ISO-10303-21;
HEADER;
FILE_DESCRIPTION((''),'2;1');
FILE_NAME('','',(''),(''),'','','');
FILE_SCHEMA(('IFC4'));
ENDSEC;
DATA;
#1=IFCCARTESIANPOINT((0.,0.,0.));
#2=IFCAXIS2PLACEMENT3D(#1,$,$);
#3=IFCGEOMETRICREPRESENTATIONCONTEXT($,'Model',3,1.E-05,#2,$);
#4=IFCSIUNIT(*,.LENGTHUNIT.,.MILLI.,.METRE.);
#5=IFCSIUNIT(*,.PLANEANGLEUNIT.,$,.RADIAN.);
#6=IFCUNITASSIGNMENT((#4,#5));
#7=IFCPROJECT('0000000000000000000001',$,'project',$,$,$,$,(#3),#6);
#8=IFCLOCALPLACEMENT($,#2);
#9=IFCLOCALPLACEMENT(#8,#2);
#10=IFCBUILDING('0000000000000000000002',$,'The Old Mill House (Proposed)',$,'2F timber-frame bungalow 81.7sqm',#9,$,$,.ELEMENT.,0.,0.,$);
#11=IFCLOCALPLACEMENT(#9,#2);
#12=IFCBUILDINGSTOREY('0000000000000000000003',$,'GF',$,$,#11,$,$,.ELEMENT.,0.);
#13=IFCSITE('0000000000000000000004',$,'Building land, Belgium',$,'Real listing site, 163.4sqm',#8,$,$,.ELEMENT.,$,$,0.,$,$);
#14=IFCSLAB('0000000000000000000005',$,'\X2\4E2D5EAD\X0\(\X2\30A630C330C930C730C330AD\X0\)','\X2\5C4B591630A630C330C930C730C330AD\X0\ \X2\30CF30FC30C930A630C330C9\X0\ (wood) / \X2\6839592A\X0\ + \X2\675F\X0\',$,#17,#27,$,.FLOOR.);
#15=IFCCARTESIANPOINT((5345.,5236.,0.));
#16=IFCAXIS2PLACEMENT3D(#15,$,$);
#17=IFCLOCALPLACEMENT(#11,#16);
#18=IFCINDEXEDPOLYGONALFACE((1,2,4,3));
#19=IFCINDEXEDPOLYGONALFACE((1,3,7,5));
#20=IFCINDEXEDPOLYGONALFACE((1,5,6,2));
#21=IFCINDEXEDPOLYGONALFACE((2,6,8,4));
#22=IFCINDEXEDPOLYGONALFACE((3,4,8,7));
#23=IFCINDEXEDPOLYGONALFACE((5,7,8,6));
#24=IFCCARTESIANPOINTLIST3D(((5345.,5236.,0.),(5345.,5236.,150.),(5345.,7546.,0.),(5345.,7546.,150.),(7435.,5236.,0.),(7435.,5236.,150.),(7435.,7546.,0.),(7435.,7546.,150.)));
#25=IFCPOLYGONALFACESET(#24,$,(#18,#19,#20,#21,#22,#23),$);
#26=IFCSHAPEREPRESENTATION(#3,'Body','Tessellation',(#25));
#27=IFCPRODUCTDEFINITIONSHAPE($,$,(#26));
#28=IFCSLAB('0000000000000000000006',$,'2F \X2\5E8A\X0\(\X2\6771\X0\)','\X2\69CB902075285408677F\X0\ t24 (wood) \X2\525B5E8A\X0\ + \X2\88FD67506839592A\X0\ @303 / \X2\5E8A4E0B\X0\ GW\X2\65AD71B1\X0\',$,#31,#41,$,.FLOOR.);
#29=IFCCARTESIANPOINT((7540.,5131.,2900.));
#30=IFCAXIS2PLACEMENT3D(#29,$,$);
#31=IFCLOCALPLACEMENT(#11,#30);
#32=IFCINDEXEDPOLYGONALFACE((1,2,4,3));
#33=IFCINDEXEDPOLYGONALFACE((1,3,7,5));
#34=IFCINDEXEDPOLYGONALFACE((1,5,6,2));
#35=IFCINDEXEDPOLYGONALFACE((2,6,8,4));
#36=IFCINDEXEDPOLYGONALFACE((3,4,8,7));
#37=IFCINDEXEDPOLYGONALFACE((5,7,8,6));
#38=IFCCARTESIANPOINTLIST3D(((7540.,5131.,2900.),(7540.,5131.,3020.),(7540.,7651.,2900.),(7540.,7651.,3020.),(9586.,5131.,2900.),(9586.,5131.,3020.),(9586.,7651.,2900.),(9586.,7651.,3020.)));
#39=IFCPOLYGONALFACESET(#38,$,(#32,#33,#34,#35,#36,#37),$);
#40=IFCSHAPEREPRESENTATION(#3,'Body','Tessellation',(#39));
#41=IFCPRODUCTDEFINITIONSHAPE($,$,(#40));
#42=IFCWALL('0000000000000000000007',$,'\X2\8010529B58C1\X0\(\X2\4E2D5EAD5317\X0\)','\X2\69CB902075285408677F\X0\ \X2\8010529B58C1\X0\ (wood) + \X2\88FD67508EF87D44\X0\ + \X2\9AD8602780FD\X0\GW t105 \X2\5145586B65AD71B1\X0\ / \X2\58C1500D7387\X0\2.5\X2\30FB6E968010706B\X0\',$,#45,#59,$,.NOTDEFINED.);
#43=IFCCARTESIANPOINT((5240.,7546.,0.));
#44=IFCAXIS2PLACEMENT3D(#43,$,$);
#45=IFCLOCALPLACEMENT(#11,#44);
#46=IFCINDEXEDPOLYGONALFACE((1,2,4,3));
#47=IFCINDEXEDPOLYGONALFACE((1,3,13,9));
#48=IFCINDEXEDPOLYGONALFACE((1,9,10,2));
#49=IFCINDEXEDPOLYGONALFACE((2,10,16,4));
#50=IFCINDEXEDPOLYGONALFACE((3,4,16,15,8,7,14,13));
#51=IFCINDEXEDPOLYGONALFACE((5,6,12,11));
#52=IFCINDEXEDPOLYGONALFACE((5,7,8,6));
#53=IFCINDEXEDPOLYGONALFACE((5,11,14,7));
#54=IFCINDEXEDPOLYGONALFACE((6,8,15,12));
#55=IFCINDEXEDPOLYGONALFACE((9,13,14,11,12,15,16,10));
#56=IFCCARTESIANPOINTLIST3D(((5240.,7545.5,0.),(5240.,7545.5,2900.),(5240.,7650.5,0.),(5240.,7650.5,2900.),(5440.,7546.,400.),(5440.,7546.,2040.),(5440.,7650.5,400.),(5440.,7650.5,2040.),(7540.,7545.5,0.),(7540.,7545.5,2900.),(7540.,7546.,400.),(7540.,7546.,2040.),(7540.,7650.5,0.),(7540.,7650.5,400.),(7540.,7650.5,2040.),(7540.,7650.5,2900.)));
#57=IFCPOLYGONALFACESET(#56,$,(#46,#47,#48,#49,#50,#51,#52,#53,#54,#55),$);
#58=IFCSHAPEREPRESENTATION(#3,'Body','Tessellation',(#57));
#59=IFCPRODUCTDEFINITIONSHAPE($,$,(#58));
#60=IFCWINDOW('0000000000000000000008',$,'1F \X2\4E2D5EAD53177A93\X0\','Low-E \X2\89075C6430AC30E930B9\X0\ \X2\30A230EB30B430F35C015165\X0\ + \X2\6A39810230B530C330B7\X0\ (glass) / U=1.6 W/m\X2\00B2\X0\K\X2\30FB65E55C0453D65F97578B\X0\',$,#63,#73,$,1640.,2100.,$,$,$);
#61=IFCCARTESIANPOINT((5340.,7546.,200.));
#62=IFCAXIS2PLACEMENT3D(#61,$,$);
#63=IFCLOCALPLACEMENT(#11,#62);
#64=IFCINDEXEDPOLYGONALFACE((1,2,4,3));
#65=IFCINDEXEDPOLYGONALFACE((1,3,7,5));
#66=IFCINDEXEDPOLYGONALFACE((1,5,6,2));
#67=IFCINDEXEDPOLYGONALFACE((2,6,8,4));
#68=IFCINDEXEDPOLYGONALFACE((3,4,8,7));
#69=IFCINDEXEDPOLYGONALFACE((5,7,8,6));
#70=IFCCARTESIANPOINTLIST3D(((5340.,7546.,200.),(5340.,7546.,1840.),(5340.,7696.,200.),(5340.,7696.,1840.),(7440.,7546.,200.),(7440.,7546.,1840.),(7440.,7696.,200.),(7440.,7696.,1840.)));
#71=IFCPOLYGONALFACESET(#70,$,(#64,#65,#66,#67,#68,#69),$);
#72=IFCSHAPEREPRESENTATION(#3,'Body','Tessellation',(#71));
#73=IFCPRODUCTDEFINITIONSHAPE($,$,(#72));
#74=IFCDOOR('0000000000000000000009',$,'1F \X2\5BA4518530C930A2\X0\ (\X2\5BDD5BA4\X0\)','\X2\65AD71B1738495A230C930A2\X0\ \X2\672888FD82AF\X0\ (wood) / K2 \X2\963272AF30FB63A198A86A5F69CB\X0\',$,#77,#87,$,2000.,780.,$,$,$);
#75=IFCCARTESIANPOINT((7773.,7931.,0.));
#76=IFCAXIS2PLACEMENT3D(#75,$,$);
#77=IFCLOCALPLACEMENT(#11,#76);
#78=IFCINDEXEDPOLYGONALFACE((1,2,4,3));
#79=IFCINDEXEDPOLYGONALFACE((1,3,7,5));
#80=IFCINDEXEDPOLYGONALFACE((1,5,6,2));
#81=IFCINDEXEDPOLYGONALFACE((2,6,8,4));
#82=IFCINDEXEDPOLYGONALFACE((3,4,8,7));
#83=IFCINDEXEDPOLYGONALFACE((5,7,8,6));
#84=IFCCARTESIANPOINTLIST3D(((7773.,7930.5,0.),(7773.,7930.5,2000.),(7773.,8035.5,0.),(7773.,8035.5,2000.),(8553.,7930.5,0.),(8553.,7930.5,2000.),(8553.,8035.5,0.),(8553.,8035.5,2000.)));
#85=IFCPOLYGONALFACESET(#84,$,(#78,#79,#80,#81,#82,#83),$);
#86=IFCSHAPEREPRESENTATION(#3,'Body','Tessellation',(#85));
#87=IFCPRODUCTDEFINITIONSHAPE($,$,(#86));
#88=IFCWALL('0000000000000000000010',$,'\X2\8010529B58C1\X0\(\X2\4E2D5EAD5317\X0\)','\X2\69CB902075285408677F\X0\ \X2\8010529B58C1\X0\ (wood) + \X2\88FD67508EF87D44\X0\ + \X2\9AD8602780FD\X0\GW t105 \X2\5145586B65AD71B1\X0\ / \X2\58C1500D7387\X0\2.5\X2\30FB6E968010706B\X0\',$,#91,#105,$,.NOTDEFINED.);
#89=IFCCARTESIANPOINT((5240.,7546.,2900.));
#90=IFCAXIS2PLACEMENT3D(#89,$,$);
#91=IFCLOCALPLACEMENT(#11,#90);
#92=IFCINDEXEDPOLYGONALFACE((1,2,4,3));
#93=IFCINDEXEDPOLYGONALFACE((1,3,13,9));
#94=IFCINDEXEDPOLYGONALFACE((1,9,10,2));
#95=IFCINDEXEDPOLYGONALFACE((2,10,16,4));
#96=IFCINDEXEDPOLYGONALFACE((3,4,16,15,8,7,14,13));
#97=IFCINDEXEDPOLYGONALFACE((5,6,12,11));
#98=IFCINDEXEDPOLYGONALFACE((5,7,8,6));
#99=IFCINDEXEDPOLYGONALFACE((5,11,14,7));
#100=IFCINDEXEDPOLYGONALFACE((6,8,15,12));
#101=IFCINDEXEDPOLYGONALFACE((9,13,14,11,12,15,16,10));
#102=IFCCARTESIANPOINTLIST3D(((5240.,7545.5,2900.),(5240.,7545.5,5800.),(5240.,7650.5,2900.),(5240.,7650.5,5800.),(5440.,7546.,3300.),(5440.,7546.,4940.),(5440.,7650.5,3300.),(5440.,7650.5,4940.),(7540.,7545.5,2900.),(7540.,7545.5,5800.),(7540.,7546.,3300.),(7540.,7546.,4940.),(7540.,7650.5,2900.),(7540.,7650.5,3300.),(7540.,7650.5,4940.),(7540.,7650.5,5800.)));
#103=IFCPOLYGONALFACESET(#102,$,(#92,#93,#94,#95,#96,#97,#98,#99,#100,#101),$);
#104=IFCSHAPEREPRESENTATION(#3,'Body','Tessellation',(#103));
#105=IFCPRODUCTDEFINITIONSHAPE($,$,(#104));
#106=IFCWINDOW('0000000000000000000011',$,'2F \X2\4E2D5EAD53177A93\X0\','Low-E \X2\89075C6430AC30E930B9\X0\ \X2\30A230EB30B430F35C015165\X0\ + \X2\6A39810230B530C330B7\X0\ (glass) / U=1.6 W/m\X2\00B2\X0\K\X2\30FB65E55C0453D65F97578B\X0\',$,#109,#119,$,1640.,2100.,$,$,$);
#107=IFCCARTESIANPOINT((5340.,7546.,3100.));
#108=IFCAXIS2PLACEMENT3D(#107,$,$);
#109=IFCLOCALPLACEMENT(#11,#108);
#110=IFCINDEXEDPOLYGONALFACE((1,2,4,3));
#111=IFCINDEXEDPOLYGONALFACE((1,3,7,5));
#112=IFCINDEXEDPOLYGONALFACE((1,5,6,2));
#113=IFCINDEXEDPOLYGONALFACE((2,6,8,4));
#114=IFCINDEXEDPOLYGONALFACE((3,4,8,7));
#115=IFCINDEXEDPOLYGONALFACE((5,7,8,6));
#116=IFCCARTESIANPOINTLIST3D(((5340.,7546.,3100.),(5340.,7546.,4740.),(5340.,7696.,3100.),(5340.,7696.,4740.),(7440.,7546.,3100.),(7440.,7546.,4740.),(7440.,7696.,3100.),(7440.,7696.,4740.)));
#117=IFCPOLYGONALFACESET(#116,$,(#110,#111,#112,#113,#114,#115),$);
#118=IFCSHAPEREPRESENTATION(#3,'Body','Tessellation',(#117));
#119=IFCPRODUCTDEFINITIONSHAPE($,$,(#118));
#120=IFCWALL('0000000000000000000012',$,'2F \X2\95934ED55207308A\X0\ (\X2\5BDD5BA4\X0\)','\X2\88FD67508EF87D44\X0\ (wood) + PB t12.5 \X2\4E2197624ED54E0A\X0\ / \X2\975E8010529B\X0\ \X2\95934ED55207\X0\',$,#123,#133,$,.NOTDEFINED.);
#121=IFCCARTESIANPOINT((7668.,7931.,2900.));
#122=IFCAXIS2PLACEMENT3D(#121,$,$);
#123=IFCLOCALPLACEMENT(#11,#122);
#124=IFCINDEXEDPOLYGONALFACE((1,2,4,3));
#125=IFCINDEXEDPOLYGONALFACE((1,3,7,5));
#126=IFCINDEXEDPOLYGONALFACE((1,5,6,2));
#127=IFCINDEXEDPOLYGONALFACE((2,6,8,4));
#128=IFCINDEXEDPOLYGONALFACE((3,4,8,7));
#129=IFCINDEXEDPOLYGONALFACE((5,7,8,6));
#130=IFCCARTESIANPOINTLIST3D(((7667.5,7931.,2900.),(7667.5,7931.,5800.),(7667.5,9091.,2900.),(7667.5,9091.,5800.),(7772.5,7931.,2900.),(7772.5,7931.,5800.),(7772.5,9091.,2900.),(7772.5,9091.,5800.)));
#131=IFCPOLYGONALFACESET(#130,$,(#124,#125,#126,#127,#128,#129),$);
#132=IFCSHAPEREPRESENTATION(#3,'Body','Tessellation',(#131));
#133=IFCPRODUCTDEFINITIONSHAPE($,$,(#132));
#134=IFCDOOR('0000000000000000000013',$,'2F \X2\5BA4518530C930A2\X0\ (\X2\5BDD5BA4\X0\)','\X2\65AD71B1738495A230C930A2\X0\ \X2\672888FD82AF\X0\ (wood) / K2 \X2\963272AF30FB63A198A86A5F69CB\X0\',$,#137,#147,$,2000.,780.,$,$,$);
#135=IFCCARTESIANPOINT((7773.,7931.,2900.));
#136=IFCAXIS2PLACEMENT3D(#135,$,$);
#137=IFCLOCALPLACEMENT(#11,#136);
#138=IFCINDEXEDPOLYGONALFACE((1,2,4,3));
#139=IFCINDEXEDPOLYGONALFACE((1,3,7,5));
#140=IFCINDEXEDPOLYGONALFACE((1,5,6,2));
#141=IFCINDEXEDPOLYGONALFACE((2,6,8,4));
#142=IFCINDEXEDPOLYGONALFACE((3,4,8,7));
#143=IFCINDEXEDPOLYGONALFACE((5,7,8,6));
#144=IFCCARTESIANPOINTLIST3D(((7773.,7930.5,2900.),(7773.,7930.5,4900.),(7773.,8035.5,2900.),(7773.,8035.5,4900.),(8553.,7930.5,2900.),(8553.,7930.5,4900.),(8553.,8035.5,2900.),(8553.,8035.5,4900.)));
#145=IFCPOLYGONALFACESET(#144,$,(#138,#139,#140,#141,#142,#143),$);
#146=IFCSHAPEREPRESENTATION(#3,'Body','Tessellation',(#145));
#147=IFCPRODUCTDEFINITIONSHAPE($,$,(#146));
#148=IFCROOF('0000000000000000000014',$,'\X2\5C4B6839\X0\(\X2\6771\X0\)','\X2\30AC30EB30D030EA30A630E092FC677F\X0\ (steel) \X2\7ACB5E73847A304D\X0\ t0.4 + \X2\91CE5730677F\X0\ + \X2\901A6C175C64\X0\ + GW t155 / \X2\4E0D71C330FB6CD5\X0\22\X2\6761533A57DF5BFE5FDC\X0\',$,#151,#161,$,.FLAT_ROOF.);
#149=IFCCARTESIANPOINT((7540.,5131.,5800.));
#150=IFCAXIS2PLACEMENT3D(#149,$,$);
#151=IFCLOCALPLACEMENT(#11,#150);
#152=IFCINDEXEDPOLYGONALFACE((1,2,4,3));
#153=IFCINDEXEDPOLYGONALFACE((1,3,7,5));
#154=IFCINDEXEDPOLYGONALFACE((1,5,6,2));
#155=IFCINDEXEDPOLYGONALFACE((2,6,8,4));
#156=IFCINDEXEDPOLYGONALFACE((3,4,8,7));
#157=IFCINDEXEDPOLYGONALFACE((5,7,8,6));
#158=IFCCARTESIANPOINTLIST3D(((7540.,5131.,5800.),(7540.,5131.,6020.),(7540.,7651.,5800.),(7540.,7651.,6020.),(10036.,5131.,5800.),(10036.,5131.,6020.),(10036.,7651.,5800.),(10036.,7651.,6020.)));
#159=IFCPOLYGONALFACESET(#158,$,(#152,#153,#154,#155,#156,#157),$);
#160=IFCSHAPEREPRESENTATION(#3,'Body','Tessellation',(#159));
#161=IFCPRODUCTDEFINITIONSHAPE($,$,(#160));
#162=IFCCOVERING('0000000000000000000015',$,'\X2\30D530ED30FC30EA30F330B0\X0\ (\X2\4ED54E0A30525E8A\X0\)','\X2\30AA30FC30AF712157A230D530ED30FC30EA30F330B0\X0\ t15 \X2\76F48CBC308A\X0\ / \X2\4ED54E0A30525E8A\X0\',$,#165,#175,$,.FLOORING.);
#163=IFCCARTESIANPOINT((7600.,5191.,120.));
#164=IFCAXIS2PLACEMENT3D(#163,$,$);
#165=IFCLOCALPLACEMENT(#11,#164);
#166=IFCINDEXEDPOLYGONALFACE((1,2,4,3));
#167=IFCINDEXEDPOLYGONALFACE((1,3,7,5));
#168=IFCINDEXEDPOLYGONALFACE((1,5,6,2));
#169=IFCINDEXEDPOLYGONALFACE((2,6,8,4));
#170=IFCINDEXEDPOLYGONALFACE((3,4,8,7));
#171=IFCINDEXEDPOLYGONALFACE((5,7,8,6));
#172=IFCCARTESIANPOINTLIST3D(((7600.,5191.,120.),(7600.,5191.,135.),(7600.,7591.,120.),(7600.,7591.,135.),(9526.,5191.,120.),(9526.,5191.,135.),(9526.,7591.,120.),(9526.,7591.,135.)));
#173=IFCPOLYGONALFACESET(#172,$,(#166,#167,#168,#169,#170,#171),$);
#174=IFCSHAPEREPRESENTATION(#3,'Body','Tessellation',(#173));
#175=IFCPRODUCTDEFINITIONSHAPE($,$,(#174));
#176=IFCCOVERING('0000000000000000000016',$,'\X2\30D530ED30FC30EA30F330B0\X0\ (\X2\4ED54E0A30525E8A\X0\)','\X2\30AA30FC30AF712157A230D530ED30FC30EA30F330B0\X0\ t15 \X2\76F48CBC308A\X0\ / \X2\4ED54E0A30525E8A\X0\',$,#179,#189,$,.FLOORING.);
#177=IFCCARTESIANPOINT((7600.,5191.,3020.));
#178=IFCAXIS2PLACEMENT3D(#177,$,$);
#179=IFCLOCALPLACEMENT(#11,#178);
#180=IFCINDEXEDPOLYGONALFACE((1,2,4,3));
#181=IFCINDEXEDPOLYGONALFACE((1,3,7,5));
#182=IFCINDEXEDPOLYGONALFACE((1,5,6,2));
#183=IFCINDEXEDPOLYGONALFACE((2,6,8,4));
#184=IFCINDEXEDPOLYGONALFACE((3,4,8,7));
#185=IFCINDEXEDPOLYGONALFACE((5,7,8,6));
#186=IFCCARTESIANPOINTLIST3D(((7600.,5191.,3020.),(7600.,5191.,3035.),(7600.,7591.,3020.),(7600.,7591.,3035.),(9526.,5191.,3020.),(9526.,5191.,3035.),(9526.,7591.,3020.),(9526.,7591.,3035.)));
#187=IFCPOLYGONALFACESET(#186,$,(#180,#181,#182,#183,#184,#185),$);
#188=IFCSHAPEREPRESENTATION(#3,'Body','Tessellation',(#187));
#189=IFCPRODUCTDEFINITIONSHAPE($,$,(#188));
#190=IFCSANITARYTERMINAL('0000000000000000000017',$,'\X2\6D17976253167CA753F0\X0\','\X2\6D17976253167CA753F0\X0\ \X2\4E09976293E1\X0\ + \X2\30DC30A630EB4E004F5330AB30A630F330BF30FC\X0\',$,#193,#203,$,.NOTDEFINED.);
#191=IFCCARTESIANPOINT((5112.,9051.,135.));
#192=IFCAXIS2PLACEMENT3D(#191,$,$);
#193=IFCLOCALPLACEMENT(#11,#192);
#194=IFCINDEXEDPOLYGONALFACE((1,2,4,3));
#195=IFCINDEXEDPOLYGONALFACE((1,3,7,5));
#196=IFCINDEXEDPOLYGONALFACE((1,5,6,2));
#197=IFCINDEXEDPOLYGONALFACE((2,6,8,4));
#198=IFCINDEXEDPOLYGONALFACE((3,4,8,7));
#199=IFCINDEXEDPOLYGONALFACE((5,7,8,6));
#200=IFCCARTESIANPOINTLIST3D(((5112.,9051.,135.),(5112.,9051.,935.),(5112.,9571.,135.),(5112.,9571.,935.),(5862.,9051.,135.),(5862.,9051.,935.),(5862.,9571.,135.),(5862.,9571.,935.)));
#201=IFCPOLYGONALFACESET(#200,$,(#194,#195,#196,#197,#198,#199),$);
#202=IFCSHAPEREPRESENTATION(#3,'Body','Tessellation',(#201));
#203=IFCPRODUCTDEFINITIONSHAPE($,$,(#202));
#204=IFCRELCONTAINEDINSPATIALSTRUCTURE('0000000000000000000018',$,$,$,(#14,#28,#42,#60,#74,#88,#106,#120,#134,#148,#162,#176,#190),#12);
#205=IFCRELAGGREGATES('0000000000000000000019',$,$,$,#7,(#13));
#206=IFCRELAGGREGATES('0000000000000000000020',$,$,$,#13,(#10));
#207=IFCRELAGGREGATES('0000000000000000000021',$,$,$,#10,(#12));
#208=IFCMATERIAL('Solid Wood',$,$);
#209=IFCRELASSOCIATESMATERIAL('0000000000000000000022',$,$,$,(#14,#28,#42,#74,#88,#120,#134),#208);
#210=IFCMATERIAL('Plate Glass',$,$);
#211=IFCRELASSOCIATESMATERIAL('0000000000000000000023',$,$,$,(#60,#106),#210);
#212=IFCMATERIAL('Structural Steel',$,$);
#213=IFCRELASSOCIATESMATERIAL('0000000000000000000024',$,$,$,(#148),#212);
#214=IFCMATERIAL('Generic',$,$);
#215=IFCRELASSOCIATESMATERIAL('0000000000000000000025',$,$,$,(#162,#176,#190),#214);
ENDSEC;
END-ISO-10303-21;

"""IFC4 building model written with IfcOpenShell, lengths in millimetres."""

from ifc_helpers import new_model, si_unit, frame, frame_2d, origin, place, context, project, spatial, rectangle, extrude, material, element, fill, save


model = new_model("IFC4")

# Units and contexts
model_context = context("Model", 3, precision=1e-05, world=origin())
ifc_project = project(units=[si_unit("LENGTHUNIT", "METRE", prefix="MILLI"), si_unit("PLANEANGLEUNIT", "RADIAN")], contexts=[model_context])

# Site, building, storey
site_placement = place(None, origin())
site = spatial("IfcSite", under=ifc_project, at=site_placement, Name="Building land, Belgium", ObjectType="Real listing site, 163.4sqm", CompositionType="ELEMENT", RefElevation=0.0)
building_placement = place(site_placement, origin())
building = spatial("IfcBuilding", under=site, at=building_placement, Name="The Old Mill House (Proposed)", ObjectType="2F timber-frame bungalow 81.7sqm", CompositionType="ELEMENT", ElevationOfRefHeight=0.0, ElevationOfTerrain=0.0)
storey_placement = place(building_placement, origin())
storey = spatial("IfcBuildingStorey", under=building, at=storey_placement, Name="GF", CompositionType="ELEMENT", Elevation=0.0)

# Slabs
ifc_material_1 = material(Name="Solid Wood")
slab_1_placement = place(storey_placement, frame((5345.0, 5236.0, 0.0)))
element("IfcSlab", 1, at=slab_1_placement, inside=storey, material=ifc_material_1, Name="中庭(ウッドデッキ)", Description="屋外ウッドデッキ ハードウッド (wood) / 根太 + 束", PredefinedType="FLOOR", context=model_context, shape_type="SweptSolid", body=[
    extrude(rectangle(XDim=2090.0, YDim=2310.0, at=frame_2d((1045.0, 1155.0))), frame((5345.0, 5236.0, 0.0)), (0.0, 0.0, 1.0), 150.0),
])
slab_2_placement = place(storey_placement, frame((7540.0, 5131.0, 2900.0)))
element("IfcSlab", 2, at=slab_2_placement, inside=storey, material=ifc_material_1, Name="2F 床(東)", Description="構造用合板 t24 (wood) 剛床 + 製材根太 @303 / 床下 GW断熱", PredefinedType="FLOOR", context=model_context, shape_type="SweptSolid", body=[
    extrude(rectangle(XDim=2046.0, YDim=2520.0, at=frame_2d((1023.0, 1260.0))), frame((7540.0, 5131.0, 2900.0)), (0.0, 0.0, 1.0), 120.0),
])

# Wall, opening, window
wall_1_placement = place(storey_placement, frame((5240.0, 7546.0, 0.0)))
wall_1 = element("IfcWall", 3, at=wall_1_placement, inside=storey, material=ifc_material_1, Name="耐力壁(中庭北)", Description="構造用合板 耐力壁 (wood) + 製材軸組 + 高性能GW t105 充填断熱 / 壁倍率2.5・準耐火", PredefinedType="NOTDEFINED", context=model_context, shape_type="SweptSolid", body=[
    extrude(rectangle(XDim=2300.0, YDim=105.0, at=frame_2d((1150.0, 52.0))), frame((5240.0, 7546.0, 0.0)), (0.0, 0.0, 1.0), 2900.0),
])
opening_1_placement = place(storey_placement, frame((5340.0, 7546.0, 200.0)))
opening_1 = element("IfcOpeningElement", 4, at=opening_1_placement, cuts=wall_1, PredefinedType="NOTDEFINED", context=model_context, shape_type="SweptSolid", body=[
    extrude(rectangle(XDim=2100.0, YDim=150.0, at=frame_2d((1050.0, 75.0))), frame((5340.0, 7546.0, 200.0)), (0.0, 0.0, 1.0), 1640.0),
])
ifc_material_2 = material(Name="Plate Glass")
window_1_placement = place(storey_placement, frame((5340.0, 7546.0, 200.0)))
window_1 = element("IfcWindow", 5, at=window_1_placement, inside=storey, material=ifc_material_2, Name="1F 中庭北窓", Description="Low-E 複層ガラス アルゴン封入 + 樹脂サッシ (glass) / U=1.6 W/m²K・日射取得型", OverallHeight=1640.0, OverallWidth=2100.0, context=model_context, shape_type="SweptSolid", body=[
    extrude(rectangle(XDim=2100.0, YDim=150.0, at=frame_2d((1050.0, 75.0))), frame((5340.0, 7546.0, 200.0)), (0.0, 0.0, 1.0), 1640.0),
])
fill(opening_1, window_1)

# Door
door_1_placement = place(storey_placement, frame((7773.0, 7931.0, 0.0)))
element("IfcDoor", 6, at=door_1_placement, inside=storey, material=ifc_material_1, Name="1F 室内ドア (寝室)", Description="断熱玄関ドア 木製芯 (wood) / K2 防犯・採風機構", OverallHeight=2000.0, OverallWidth=780.0, context=model_context, shape_type="SweptSolid", body=[
    extrude(rectangle(XDim=780.0, YDim=105.0, at=frame_2d((390.0, 52.0))), frame((7773.0, 7931.0, 0.0)), (0.0, 0.0, 1.0), 2000.0),
])

# Wall, opening, window
wall_2_placement = place(storey_placement, frame((5240.0, 7546.0, 2900.0)))
wall_2 = element("IfcWall", 7, at=wall_2_placement, inside=storey, material=ifc_material_1, Name="耐力壁(中庭北)", Description="構造用合板 耐力壁 (wood) + 製材軸組 + 高性能GW t105 充填断熱 / 壁倍率2.5・準耐火", PredefinedType="NOTDEFINED", context=model_context, shape_type="SweptSolid", body=[
    extrude(rectangle(XDim=2300.0, YDim=105.0, at=frame_2d((1150.0, 52.0))), frame((5240.0, 7546.0, 2900.0)), (0.0, 0.0, 1.0), 2900.0),
])
opening_2_placement = place(storey_placement, frame((5340.0, 7546.0, 3100.0)))
opening_2 = element("IfcOpeningElement", 8, at=opening_2_placement, cuts=wall_2, PredefinedType="NOTDEFINED", context=model_context, shape_type="SweptSolid", body=[
    extrude(rectangle(XDim=2100.0, YDim=150.0, at=frame_2d((1050.0, 75.0))), frame((5340.0, 7546.0, 3100.0)), (0.0, 0.0, 1.0), 1640.0),
])
window_2_placement = place(storey_placement, frame((5340.0, 7546.0, 3100.0)))
window_2 = element("IfcWindow", 9, at=window_2_placement, inside=storey, material=ifc_material_2, Name="2F 中庭北窓", Description="Low-E 複層ガラス アルゴン封入 + 樹脂サッシ (glass) / U=1.6 W/m²K・日射取得型", OverallHeight=1640.0, OverallWidth=2100.0, context=model_context, shape_type="SweptSolid", body=[
    extrude(rectangle(XDim=2100.0, YDim=150.0, at=frame_2d((1050.0, 75.0))), frame((5340.0, 7546.0, 3100.0)), (0.0, 0.0, 1.0), 1640.0),
])
fill(opening_2, window_2)

# Wall
wall_3_placement = place(storey_placement, frame((7668.0, 7931.0, 2900.0)))
element("IfcWall", 10, at=wall_3_placement, inside=storey, material=ifc_material_1, Name="2F 間仕切り (寝室)", Description="製材軸組 (wood) + PB t12.5 両面仕上 / 非耐力 間仕切", PredefinedType="NOTDEFINED", context=model_context, shape_type="SweptSolid", body=[
    extrude(rectangle(XDim=105.0, YDim=1160.0, at=frame_2d((52.0, 580.0))), frame((7668.0, 7931.0, 2900.0)), (0.0, 0.0, 1.0), 2900.0),
])

# Door
door_2_placement = place(storey_placement, frame((7773.0, 7931.0, 2900.0)))
element("IfcDoor", 11, at=door_2_placement, inside=storey, material=ifc_material_1, Name="2F 室内ドア (寝室)", Description="断熱玄関ドア 木製芯 (wood) / K2 防犯・採風機構", OverallHeight=2000.0, OverallWidth=780.0, context=model_context, shape_type="SweptSolid", body=[
    extrude(rectangle(XDim=780.0, YDim=105.0, at=frame_2d((390.0, 52.0))), frame((7773.0, 7931.0, 2900.0)), (0.0, 0.0, 1.0), 2000.0),
])

# Roof
ifc_material_3 = material(Name="Structural Steel")
for number, where, name in (
    (12, (7540.0, 5131.0, 5800.0), "屋根(東)"),
):
    element("IfcRoof", number, at=place(storey_placement, frame(where)), inside=storey, material=ifc_material_3, Name=name, Description="ガルバリウム鋼板 (steel) 立平葺き t0.4 + 野地板 + 通気層 + GW t155 / 不燃・法22条区域対応", PredefinedType="FLAT_ROOF", context=model_context, shape_type="SweptSolid", body=[
        extrude(rectangle(XDim=2496.0, YDim=2520.0, at=frame_2d((1248.0, 1260.0))), frame((7540.0, 5131.0, 5800.0)), (0.0, 0.0, 1.0), 220.0),
    ])

# Coverings
ifc_material_4 = material(Name="Generic")
covering_1_placement = place(storey_placement, frame((7600.0, 5191.0, 120.0)))
element("IfcCovering", 13, at=covering_1_placement, inside=storey, material=ifc_material_4, Name="フローリング (仕上げ床)", Description="オーク無垢フローリング t15 直貼り / 仕上げ床", PredefinedType="FLOORING", context=model_context, shape_type="SweptSolid", body=[
    extrude(rectangle(XDim=1926.0, YDim=2400.0, at=frame_2d((963.0, 1200.0))), frame((7600.0, 5191.0, 120.0)), (0.0, 0.0, 1.0), 15.0),
])
covering_2_placement = place(storey_placement, frame((7600.0, 5191.0, 3020.0)))
element("IfcCovering", 14, at=covering_2_placement, inside=storey, material=ifc_material_4, Name="フローリング (仕上げ床)", Description="オーク無垢フローリング t15 直貼り / 仕上げ床", PredefinedType="FLOORING", context=model_context, shape_type="SweptSolid", body=[
    extrude(rectangle(XDim=1926.0, YDim=2400.0, at=frame_2d((963.0, 1200.0))), frame((7600.0, 5191.0, 3020.0)), (0.0, 0.0, 1.0), 15.0),
])

# Sanitary terminal
sanitary_terminal_1_placement = place(storey_placement, frame((5112.0, 9051.0, 135.0)))
element("IfcSanitaryTerminal", 15, at=sanitary_terminal_1_placement, inside=storey, material=ifc_material_4, Name="洗面化粧台", Description="洗面化粧台 三面鏡 + ボウル一体カウンター", PredefinedType="NOTDEFINED", context=model_context, shape_type="SweptSolid", body=[
    extrude(rectangle(XDim=750.0, YDim=520.0, at=frame_2d((375.0, 260.0))), frame((5112.0, 9051.0, 135.0)), (0.0, 0.0, 1.0), 800.0),
])

save(model, "model.ifc")
